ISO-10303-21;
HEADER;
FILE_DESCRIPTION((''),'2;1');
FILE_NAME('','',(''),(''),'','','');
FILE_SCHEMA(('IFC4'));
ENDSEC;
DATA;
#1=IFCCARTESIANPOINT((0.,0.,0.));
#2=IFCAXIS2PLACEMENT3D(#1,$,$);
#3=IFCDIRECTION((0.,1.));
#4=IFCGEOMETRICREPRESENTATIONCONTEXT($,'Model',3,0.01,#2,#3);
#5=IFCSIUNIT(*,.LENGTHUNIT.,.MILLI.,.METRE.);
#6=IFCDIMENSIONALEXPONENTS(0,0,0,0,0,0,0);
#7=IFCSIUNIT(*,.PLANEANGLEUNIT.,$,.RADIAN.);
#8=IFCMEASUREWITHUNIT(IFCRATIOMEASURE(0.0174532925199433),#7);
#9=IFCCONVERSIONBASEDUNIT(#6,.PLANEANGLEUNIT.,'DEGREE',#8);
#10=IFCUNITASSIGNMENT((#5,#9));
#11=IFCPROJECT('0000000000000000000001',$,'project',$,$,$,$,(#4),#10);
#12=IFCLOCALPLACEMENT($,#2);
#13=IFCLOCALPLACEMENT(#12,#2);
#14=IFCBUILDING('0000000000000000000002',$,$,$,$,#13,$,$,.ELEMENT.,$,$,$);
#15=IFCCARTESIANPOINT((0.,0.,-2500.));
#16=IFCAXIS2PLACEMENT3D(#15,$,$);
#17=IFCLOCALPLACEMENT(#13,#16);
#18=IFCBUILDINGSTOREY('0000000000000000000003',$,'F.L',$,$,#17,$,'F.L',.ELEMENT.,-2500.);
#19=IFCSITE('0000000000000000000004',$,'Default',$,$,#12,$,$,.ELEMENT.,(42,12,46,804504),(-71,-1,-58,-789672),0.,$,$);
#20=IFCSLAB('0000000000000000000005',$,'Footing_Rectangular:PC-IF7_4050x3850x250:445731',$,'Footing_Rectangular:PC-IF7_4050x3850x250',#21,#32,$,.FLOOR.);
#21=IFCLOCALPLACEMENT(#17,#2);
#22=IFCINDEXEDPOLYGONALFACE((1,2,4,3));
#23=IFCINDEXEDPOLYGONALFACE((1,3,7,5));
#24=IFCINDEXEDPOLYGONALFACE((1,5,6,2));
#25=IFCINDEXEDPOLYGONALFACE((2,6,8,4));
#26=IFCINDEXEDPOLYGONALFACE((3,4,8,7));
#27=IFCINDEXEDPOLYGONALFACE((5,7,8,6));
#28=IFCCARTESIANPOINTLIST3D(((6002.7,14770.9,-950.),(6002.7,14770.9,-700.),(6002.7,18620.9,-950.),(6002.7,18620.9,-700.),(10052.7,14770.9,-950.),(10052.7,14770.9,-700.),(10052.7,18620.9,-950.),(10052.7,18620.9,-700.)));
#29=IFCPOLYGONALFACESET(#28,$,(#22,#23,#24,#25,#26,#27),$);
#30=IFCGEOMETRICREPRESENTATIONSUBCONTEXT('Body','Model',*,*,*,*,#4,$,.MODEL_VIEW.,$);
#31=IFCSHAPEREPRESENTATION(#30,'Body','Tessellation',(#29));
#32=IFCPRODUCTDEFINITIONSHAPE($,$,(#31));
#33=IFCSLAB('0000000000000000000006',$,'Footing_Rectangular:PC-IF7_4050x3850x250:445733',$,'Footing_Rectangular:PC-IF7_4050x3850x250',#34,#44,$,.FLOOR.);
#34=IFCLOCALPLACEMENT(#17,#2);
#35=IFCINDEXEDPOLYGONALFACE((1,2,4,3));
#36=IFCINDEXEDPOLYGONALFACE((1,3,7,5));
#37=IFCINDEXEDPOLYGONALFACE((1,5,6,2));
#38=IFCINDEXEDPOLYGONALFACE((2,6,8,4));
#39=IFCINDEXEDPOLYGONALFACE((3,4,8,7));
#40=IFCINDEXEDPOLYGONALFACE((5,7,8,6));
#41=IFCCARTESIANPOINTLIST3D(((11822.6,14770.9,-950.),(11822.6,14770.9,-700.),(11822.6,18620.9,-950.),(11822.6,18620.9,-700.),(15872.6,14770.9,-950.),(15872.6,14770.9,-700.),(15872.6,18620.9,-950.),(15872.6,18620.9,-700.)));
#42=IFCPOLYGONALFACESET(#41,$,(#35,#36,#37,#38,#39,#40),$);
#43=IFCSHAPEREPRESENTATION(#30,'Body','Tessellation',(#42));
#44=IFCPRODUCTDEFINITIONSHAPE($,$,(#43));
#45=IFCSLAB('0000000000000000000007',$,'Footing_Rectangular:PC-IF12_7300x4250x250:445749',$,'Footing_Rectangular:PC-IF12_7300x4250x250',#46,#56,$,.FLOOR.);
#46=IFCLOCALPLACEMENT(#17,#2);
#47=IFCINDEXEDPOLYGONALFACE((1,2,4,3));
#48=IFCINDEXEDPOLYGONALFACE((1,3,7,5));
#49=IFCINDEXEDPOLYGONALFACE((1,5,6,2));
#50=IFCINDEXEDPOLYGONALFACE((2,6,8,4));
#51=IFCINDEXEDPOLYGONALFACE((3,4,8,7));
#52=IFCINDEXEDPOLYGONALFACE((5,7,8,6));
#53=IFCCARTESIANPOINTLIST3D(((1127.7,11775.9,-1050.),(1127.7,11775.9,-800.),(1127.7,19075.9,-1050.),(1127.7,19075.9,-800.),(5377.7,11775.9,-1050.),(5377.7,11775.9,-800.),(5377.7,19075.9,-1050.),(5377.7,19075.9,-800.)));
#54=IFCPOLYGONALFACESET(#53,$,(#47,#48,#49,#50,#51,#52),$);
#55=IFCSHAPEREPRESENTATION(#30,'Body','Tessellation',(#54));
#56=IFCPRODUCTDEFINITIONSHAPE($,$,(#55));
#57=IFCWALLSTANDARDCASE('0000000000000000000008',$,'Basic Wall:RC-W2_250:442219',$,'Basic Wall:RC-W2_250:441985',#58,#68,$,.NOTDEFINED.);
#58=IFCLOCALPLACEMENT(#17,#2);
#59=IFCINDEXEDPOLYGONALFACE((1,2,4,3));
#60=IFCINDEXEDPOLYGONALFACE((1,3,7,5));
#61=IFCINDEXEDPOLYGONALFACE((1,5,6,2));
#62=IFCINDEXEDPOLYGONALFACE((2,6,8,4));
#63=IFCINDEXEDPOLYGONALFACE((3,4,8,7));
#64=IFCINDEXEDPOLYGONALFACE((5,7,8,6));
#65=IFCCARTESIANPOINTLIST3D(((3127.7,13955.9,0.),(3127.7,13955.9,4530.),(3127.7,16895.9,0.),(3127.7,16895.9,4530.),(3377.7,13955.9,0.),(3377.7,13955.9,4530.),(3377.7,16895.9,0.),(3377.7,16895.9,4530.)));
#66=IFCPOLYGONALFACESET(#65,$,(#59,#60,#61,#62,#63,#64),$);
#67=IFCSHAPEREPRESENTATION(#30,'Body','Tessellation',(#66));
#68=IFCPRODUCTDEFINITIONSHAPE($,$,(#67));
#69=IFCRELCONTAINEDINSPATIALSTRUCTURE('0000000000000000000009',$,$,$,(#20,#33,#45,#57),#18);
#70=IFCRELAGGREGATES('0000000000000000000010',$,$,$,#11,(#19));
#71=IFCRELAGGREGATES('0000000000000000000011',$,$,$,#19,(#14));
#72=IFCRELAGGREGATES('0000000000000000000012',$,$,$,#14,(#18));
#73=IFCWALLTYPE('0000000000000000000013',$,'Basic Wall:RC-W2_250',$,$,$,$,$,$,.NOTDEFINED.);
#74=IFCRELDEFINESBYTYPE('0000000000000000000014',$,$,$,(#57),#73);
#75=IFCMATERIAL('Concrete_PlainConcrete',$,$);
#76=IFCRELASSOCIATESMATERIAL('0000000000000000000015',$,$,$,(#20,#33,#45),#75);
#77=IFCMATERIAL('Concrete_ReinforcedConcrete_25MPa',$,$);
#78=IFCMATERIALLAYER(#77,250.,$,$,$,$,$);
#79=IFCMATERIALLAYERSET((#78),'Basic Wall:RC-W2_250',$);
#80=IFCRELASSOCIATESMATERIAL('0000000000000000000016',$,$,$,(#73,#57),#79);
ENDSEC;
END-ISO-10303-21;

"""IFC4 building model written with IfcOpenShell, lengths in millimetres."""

from ifc_helpers import new_model, entity, si_unit, converted_unit, direction, frame, frame_2d, origin, origin_2d_with_axis, place, context, subcontext, project, spatial, rectangle, extrude, material, layer, layer_set, layer_usage, type_object, element, save


model = new_model("IFC4")

# Units and contexts
model_context = context("Model", 3, precision=0.01, world=origin(), true_north=direction((0.0, 1.0)))
body_context = subcontext(model_context, "Body", "Model", "MODEL_VIEW")
ifc_project = project(units=[si_unit("LENGTHUNIT", "METRE", prefix="MILLI"), converted_unit("PLANEANGLEUNIT", "DEGREE", entity("IfcRatioMeasure", 0.0174532925199433), si_unit("PLANEANGLEUNIT", "RADIAN"), dimensions=[0, 0, 0, 0, 0, 0, 0])], contexts=[model_context])

# Site, building, storey
site_placement = place(None, origin())
site = spatial("IfcSite", under=ifc_project, at=site_placement, Name="Default", CompositionType="ELEMENT", RefLatitude=(42, 12, 46, 804504), RefLongitude=(-71, -1, -58, -789672), RefElevation=0.0)
building_placement = place(site_placement, origin())
building = spatial("IfcBuilding", under=site, at=building_placement, CompositionType="ELEMENT")
storey_placement = place(building_placement, frame((0.0, 0.0, -2500.0)))
storey = spatial("IfcBuildingStorey", under=building, at=storey_placement, Name="F.L", LongName="F.L", CompositionType="ELEMENT", Elevation=-2500.0)

# Slabs
ifc_material_1 = material(Name="Concrete_ReinforcedConcrete_25MPa")
ifc_material_2 = material(Name="Concrete_PlainConcrete")
slab_1_placement = place(storey_placement, frame((6002.7, 14770.9, -950.0)))
element("IfcSlab", 1, at=slab_1_placement, inside=storey, material=ifc_material_2, Name="Footing_Rectangular:PC-IF7_4050x3850x250:445731", ObjectType="Footing_Rectangular:PC-IF7_4050x3850x250", PredefinedType="FLOOR", context=body_context, shape_type="SweptSolid", body=[
    extrude(rectangle(XDim=3850.0, YDim=4050.0, at=frame_2d((0.0, 0.0), x_axis=(1.0, 0.0))), frame((2025.0, 1925.0, 0.0), z_axis=(0.0, 0.0, 1.0), x_axis=(0.0, 1.0, 0.0)), (0.0, 0.0, 1.0), 250.0),
])
slab_2_placement = place(storey_placement, frame((11822.6, 14770.9, -950.0)))
element("IfcSlab", 2, at=slab_2_placement, inside=storey, material=ifc_material_2, Name="Footing_Rectangular:PC-IF7_4050x3850x250:445733", ObjectType="Footing_Rectangular:PC-IF7_4050x3850x250", PredefinedType="FLOOR", context=body_context, shape_type="SweptSolid", body=[
    extrude(rectangle(XDim=3850.0, YDim=4050.0, at=frame_2d((0.0, 0.0), x_axis=(1.0, 0.0))), frame((2025.0, 1925.0, 0.0), z_axis=(0.0, 0.0, 1.0), x_axis=(0.0, 1.0, 0.0)), (0.0, 0.0, 1.0), 250.0),
])
slab_3_placement = place(storey_placement, frame((1127.7, 11775.9, -1050.0)))
element("IfcSlab", 3, at=slab_3_placement, inside=storey, material=ifc_material_2, Name="Footing_Rectangular:PC-IF12_7300x4250x250:445749", ObjectType="Footing_Rectangular:PC-IF12_7300x4250x250", PredefinedType="FLOOR", context=body_context, shape_type="SweptSolid", body=[
    extrude(rectangle(XDim=4250.0, YDim=7300.0, at=origin_2d_with_axis()), frame((2125.0, 3650.0, 0.0), z_axis=(0.0, 0.0, 1.0), x_axis=(-1.0, 0.0, 0.0)), (0.0, 0.0, 1.0), 250.0),
])

# Wall
ifc_layer_1 = layer(ifc_material_1, 250.0)
ifc_layer_set_1 = layer_set([ifc_layer_1], Name="Basic Wall:RC-W2_250")
ifc_layer_usage_1 = layer_usage(ifc_layer_set_1, "AXIS2", "NEGATIVE", 125.0)
wall_type = type_object("IfcWallType", Name="Basic Wall:RC-W2_250", PredefinedType="NOTDEFINED", material=ifc_layer_set_1)
wall_placement = place(storey_placement, frame((3252.7, 13955.9, 0.0), z_axis=(0.0, 0.0, 1.0), x_axis=(0.0, 1.0, 0.0)))
element("IfcWallStandardCase", 4, at=wall_placement, inside=storey, type_object=wall_type, material=ifc_layer_usage_1, Name="Basic Wall:RC-W2_250:442219", ObjectType="Basic Wall:RC-W2_250:441985", PredefinedType="NOTDEFINED", context=body_context, shape_type="SweptSolid", body=[
    extrude(rectangle(XDim=2940.0, YDim=250.0, at=frame_2d((1470.0, 0.0), x_axis=(-1.0, 0.0))), origin(), (0.0, 0.0, 1.0), 4530.0),
])

save(model, "model.ifc")
